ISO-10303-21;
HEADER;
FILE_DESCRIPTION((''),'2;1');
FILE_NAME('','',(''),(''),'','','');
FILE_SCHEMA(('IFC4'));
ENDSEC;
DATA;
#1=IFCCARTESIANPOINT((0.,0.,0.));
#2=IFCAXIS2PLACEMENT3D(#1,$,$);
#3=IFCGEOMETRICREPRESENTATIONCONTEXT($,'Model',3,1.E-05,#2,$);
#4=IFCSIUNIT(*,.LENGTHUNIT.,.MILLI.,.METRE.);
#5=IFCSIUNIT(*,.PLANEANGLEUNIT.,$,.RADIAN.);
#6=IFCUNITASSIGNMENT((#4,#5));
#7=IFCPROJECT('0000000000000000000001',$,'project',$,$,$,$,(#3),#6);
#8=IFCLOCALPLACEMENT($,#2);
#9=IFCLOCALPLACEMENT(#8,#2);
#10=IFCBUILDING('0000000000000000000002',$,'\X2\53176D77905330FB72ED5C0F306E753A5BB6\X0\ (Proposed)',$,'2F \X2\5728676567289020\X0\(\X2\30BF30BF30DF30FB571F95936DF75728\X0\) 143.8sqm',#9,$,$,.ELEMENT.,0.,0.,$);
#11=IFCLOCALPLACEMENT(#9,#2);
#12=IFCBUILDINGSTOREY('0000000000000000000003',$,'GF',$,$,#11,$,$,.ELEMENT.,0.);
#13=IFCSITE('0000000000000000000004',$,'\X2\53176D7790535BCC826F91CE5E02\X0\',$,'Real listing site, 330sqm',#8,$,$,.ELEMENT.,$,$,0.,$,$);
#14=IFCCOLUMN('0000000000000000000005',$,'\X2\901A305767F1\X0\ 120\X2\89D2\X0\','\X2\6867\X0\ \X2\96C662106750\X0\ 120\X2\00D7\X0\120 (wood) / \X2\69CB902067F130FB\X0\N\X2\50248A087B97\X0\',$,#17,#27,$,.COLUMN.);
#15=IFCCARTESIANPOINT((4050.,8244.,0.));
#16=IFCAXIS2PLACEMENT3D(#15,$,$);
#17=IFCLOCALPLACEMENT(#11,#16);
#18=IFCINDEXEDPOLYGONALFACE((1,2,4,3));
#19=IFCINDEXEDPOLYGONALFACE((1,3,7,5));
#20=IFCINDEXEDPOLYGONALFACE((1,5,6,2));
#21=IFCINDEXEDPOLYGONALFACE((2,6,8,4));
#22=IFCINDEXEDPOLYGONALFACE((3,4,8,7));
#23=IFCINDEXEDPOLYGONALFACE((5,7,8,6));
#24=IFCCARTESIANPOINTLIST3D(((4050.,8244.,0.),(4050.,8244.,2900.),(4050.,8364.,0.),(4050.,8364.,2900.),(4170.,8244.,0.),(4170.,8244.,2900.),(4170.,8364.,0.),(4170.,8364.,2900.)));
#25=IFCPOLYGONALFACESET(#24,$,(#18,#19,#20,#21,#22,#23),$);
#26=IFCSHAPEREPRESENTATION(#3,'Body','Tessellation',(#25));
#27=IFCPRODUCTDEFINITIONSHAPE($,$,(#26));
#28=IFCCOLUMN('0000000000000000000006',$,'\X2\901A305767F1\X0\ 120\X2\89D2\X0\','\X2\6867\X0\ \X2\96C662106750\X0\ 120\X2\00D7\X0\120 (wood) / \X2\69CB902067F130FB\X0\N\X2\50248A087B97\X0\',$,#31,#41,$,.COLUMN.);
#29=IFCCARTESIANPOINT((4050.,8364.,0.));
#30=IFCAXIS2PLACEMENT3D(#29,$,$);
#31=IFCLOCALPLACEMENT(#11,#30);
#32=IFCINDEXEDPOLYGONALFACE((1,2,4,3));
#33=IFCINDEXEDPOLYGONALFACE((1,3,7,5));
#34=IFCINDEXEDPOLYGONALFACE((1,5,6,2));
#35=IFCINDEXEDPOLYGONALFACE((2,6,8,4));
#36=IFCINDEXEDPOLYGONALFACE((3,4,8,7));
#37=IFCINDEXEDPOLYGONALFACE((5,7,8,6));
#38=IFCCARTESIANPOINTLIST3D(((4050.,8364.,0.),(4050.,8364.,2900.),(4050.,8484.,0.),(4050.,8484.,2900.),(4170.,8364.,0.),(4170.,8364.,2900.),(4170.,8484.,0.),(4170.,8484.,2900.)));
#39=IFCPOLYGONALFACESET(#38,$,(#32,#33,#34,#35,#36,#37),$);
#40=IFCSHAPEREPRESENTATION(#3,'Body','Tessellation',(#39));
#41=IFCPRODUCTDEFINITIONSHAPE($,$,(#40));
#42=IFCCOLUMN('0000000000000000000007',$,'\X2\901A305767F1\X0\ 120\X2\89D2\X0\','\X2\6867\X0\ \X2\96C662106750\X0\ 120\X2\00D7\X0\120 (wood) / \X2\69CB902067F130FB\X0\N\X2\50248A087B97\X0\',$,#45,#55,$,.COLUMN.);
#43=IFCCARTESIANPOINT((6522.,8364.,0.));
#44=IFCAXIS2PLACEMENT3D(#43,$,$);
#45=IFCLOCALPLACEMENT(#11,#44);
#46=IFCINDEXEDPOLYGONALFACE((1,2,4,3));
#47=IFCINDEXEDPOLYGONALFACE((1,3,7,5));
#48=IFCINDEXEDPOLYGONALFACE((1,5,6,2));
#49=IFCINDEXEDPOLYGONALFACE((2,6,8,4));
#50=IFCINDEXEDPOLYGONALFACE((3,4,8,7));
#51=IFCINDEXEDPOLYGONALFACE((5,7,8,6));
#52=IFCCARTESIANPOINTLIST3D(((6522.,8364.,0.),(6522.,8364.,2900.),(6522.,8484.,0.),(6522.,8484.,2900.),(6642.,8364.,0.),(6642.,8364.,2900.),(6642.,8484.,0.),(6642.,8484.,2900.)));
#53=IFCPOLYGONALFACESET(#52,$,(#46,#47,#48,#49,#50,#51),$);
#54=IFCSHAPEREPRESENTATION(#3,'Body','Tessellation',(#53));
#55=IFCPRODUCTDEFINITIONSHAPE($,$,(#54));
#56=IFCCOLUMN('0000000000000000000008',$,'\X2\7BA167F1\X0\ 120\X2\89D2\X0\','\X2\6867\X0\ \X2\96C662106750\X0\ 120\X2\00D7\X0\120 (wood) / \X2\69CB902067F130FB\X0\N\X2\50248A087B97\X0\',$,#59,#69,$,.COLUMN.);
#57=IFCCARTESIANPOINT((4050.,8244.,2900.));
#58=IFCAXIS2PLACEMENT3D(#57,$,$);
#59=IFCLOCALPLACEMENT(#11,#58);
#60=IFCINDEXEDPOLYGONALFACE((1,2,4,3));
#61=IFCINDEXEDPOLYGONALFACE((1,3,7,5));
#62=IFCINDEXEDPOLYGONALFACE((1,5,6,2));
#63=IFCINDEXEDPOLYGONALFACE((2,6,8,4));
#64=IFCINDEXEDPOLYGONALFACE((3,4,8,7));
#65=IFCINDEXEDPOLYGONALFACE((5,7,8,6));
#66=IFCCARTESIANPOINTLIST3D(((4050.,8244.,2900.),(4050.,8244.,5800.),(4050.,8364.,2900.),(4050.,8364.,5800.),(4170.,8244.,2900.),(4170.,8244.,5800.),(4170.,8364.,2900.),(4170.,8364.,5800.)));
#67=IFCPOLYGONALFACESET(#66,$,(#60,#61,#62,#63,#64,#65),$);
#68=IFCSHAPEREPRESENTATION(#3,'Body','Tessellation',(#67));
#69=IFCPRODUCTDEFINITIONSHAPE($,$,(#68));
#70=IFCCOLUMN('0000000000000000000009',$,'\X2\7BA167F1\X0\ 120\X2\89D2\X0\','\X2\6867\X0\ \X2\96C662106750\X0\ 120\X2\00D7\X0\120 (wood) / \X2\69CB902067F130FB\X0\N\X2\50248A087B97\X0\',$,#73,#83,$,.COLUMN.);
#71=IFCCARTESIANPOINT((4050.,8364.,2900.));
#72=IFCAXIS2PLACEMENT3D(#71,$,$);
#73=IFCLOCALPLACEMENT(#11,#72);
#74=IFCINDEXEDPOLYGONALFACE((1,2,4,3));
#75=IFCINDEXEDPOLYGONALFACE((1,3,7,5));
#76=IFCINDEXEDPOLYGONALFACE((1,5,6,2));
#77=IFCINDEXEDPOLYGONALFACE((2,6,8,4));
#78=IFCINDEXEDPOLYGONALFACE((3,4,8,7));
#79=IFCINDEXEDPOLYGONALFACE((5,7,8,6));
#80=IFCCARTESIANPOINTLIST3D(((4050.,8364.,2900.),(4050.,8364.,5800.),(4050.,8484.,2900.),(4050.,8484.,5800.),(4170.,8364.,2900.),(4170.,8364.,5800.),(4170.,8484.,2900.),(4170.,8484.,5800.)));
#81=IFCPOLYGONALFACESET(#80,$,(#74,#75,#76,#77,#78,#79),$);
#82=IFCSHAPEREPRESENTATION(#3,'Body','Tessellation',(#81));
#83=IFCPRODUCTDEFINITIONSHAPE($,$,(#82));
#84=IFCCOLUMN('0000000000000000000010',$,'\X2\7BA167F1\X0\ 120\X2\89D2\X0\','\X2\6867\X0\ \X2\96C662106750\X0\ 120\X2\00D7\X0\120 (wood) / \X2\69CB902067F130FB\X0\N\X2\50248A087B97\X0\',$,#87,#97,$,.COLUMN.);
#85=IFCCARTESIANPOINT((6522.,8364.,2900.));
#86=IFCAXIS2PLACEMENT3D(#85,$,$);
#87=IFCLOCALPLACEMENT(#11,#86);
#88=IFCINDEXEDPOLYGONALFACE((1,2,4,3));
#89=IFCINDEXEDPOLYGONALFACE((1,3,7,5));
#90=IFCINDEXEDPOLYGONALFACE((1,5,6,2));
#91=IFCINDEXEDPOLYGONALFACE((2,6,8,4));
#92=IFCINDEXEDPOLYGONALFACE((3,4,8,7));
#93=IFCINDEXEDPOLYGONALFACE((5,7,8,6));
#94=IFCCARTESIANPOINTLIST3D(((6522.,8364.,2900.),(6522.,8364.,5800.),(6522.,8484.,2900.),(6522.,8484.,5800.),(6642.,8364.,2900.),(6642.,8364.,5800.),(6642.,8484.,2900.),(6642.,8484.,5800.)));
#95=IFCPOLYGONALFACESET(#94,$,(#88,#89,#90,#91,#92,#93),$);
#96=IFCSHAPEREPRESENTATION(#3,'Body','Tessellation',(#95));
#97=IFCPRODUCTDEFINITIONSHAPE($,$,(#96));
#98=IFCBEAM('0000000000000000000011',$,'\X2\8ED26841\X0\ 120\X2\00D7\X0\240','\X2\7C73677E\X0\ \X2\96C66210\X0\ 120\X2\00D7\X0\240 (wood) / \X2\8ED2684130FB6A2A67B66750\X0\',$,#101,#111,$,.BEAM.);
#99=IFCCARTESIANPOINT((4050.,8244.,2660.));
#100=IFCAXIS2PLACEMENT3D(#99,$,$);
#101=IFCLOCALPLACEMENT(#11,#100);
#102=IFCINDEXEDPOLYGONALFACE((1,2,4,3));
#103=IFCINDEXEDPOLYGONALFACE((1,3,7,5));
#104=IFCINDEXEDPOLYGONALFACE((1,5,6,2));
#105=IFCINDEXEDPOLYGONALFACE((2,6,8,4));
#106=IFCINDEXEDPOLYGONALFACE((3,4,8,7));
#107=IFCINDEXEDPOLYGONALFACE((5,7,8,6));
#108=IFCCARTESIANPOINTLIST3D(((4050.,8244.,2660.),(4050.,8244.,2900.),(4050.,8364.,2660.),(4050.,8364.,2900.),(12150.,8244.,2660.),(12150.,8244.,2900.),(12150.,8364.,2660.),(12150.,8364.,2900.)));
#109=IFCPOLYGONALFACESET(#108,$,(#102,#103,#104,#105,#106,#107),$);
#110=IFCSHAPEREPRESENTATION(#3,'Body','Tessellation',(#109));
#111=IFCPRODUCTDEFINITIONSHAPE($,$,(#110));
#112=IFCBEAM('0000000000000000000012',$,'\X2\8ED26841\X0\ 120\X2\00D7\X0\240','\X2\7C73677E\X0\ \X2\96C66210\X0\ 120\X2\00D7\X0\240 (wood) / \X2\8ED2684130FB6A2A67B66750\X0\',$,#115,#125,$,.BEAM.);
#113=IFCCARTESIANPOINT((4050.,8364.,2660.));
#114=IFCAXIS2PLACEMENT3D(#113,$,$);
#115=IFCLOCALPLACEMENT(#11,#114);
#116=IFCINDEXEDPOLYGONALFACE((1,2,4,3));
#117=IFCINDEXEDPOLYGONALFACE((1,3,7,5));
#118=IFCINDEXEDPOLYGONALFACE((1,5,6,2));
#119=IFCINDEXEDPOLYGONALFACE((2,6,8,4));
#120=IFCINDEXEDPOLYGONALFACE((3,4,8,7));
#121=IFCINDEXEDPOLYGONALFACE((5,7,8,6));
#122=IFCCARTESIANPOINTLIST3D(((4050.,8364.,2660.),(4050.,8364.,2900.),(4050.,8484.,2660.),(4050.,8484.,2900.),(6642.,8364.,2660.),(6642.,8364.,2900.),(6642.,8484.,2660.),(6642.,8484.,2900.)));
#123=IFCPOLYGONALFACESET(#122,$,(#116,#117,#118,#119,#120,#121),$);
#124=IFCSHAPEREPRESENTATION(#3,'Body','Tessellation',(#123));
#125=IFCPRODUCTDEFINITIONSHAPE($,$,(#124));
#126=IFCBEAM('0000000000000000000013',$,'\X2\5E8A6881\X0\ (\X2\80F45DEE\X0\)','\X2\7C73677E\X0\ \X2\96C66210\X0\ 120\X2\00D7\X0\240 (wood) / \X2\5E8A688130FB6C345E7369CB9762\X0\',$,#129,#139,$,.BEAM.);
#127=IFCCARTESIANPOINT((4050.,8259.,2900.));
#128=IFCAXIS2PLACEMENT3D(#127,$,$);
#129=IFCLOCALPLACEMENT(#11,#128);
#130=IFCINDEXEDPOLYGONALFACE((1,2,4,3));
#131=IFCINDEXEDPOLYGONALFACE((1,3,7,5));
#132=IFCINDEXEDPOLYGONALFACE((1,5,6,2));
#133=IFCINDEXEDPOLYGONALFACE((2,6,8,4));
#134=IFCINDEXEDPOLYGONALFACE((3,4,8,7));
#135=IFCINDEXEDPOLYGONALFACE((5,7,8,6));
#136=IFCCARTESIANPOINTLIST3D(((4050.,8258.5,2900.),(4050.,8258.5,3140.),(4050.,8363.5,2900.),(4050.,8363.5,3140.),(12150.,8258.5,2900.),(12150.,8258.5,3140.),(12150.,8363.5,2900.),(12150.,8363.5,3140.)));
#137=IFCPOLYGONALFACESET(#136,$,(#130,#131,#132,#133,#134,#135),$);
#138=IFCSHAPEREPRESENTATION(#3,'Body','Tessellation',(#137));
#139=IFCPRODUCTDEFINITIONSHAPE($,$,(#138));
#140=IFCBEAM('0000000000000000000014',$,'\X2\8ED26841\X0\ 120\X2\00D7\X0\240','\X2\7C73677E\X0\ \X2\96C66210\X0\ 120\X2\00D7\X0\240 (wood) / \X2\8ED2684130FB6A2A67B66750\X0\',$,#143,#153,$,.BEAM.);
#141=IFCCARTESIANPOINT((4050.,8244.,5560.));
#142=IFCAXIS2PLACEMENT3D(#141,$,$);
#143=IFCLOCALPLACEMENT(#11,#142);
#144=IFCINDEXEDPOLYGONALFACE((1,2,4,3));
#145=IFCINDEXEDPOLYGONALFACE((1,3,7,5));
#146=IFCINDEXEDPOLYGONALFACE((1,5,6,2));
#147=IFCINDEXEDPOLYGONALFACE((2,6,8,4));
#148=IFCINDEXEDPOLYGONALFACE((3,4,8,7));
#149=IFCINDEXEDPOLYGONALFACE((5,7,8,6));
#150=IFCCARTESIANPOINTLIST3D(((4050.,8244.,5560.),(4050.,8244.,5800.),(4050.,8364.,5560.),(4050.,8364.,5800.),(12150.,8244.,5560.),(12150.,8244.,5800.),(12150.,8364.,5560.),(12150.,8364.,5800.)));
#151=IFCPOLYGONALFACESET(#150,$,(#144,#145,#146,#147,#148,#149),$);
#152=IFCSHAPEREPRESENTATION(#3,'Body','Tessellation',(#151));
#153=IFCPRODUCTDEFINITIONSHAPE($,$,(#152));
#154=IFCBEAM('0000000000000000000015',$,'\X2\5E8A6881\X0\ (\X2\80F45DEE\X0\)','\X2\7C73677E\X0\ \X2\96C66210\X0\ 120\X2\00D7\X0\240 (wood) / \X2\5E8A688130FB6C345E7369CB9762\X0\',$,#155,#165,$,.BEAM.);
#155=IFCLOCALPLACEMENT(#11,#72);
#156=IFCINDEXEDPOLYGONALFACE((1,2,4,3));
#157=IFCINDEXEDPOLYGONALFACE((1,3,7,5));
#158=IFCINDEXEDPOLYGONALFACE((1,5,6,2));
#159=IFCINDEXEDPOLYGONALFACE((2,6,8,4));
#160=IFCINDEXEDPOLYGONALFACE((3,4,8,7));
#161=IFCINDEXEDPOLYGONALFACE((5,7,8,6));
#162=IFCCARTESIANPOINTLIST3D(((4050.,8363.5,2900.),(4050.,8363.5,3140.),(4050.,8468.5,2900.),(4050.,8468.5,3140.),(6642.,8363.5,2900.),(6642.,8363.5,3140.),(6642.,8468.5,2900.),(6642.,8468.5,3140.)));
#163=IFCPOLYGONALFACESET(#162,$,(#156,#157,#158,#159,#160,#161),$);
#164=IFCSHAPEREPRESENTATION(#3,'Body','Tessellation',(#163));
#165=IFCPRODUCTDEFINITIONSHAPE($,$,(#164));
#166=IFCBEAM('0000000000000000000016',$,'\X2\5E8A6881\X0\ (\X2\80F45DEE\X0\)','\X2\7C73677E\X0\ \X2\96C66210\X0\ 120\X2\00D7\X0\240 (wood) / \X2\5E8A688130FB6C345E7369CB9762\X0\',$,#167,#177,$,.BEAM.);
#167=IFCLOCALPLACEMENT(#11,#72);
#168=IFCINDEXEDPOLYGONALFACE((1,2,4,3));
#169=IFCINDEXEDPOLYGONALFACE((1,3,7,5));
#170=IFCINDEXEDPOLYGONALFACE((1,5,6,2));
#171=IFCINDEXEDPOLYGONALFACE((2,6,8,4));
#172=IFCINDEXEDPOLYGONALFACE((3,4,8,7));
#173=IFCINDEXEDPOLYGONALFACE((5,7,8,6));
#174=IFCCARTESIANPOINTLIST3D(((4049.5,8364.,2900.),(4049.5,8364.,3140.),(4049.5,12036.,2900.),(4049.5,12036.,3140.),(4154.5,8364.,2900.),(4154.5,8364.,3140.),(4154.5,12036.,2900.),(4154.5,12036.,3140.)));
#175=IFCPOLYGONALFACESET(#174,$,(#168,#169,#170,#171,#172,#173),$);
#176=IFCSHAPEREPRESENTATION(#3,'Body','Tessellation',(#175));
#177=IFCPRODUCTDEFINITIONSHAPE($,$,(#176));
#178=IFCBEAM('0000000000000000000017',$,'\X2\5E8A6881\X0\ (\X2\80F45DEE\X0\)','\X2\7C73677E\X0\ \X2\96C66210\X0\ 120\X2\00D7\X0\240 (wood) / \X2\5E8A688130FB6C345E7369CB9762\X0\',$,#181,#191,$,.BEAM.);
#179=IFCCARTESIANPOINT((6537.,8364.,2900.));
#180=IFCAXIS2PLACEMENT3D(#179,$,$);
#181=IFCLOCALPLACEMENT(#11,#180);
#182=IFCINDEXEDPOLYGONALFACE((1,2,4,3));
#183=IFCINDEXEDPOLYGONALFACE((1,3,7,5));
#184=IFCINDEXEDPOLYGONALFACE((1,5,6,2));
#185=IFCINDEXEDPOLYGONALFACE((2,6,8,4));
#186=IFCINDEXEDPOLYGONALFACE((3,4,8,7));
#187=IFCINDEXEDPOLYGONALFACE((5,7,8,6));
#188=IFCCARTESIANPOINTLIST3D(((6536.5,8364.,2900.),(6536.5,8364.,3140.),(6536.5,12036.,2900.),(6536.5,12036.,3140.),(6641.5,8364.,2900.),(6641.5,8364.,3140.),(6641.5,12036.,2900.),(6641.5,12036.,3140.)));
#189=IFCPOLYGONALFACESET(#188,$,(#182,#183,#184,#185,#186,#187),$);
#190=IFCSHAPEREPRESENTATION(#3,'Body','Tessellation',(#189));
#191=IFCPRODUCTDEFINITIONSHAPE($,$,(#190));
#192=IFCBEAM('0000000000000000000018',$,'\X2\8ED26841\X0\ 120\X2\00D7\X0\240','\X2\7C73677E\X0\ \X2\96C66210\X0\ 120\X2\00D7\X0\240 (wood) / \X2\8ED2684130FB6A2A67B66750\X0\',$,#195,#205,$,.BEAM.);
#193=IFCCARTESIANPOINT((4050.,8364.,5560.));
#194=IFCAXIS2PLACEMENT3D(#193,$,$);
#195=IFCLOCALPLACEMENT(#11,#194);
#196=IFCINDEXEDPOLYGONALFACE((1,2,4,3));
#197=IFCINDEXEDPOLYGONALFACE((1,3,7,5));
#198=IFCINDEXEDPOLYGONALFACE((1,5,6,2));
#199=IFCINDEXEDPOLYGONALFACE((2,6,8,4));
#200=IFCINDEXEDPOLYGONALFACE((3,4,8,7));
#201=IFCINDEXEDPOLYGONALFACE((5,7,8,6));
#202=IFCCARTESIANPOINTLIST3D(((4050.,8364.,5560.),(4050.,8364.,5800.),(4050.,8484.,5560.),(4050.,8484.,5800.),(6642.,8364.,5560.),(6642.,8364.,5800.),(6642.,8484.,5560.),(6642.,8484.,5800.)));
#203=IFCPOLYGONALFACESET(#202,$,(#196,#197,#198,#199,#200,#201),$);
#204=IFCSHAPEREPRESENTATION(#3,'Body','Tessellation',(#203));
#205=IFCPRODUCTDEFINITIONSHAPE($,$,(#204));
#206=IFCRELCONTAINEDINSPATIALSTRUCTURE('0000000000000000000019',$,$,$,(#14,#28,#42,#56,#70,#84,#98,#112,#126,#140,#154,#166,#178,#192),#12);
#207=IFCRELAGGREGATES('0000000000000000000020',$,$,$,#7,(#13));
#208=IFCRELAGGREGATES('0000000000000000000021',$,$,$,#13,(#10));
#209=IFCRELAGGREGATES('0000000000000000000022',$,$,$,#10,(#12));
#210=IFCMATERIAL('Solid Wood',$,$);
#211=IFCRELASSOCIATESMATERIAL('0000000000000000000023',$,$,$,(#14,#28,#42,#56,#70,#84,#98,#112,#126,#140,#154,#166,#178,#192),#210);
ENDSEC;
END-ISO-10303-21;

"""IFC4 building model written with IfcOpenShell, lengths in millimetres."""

from ifc_helpers import new_model, si_unit, frame, frame_2d, origin, place, context, project, spatial, rectangle, extrude, material, element, save


model = new_model("IFC4")

# Units and contexts
model_context = context("Model", 3, precision=1e-05, world=origin())
ifc_project = project(units=[si_unit("LENGTHUNIT", "METRE", prefix="MILLI"), si_unit("PLANEANGLEUNIT", "RADIAN")], contexts=[model_context])

# Site, building, storey
site_placement = place(None, origin())
site = spatial("IfcSite", under=ifc_project, at=site_placement, Name="北海道富良野市", ObjectType="Real listing site, 330sqm", CompositionType="ELEMENT", RefElevation=0.0)
building_placement = place(site_placement, origin())
building = spatial("IfcBuilding", under=site, at=building_placement, Name="北海道・狭小の町家 (Proposed)", ObjectType="2F 在来木造(タタミ・土間混在) 143.8sqm", CompositionType="ELEMENT", ElevationOfRefHeight=0.0, ElevationOfTerrain=0.0)
storey_placement = place(building_placement, origin())
storey = spatial("IfcBuildingStorey", under=building, at=storey_placement, Name="GF", CompositionType="ELEMENT", Elevation=0.0)

# Columns
ifc_material_1 = material(Name="Solid Wood")
column_1_placement = place(storey_placement, frame((4050.0, 8244.0, 0.0)))
element("IfcColumn", 1, at=column_1_placement, inside=storey, material=ifc_material_1, Name="通し柱 120角", Description="桧 集成材 120×120 (wood) / 構造柱・N値計算", PredefinedType="COLUMN", context=model_context, shape_type="SweptSolid", body=[
    extrude(rectangle(XDim=120.0, YDim=120.0, at=frame_2d((60.0, 60.0))), frame((4050.0, 8244.0, 0.0)), (0.0, 0.0, 1.0), 2900.0),
])
column_2_placement = place(storey_placement, frame((4050.0, 8364.0, 0.0)))
element("IfcColumn", 2, at=column_2_placement, inside=storey, material=ifc_material_1, Name="通し柱 120角", Description="桧 集成材 120×120 (wood) / 構造柱・N値計算", PredefinedType="COLUMN", context=model_context, shape_type="SweptSolid", body=[
    extrude(rectangle(XDim=120.0, YDim=120.0, at=frame_2d((60.0, 60.0))), frame((4050.0, 8364.0, 0.0)), (0.0, 0.0, 1.0), 2900.0),
])
column_3_placement = place(storey_placement, frame((6522.0, 8364.0, 0.0)))
element("IfcColumn", 3, at=column_3_placement, inside=storey, material=ifc_material_1, Name="通し柱 120角", Description="桧 集成材 120×120 (wood) / 構造柱・N値計算", PredefinedType="COLUMN", context=model_context, shape_type="SweptSolid", body=[
    extrude(rectangle(XDim=120.0, YDim=120.0, at=frame_2d((60.0, 60.0))), frame((6522.0, 8364.0, 0.0)), (0.0, 0.0, 1.0), 2900.0),
])
column_4_placement = place(storey_placement, frame((4050.0, 8244.0, 2900.0)))
element("IfcColumn", 4, at=column_4_placement, inside=storey, material=ifc_material_1, Name="管柱 120角", Description="桧 集成材 120×120 (wood) / 構造柱・N値計算", PredefinedType="COLUMN", context=model_context, shape_type="SweptSolid", body=[
    extrude(rectangle(XDim=120.0, YDim=120.0, at=frame_2d((60.0, 60.0))), frame((4050.0, 8244.0, 2900.0)), (0.0, 0.0, 1.0), 2900.0),
])
column_5_placement = place(storey_placement, frame((4050.0, 8364.0, 2900.0)))
element("IfcColumn", 5, at=column_5_placement, inside=storey, material=ifc_material_1, Name="管柱 120角", Description="桧 集成材 120×120 (wood) / 構造柱・N値計算", PredefinedType="COLUMN", context=model_context, shape_type="SweptSolid", body=[
    extrude(rectangle(XDim=120.0, YDim=120.0, at=frame_2d((60.0, 60.0))), frame((4050.0, 8364.0, 2900.0)), (0.0, 0.0, 1.0), 2900.0),
])
column_6_placement = place(storey_placement, frame((6522.0, 8364.0, 2900.0)))
element("IfcColumn", 6, at=column_6_placement, inside=storey, material=ifc_material_1, Name="管柱 120角", Description="桧 集成材 120×120 (wood) / 構造柱・N値計算", PredefinedType="COLUMN", context=model_context, shape_type="SweptSolid", body=[
    extrude(rectangle(XDim=120.0, YDim=120.0, at=frame_2d((60.0, 60.0))), frame((6522.0, 8364.0, 2900.0)), (0.0, 0.0, 1.0), 2900.0),
])

# Beams
beam_1_placement = place(storey_placement, frame((4050.0, 8244.0, 2660.0)))
element("IfcBeam", 7, at=beam_1_placement, inside=storey, material=ifc_material_1, Name="軒桁 120×240", Description="米松 集成 120×240 (wood) / 軒桁・横架材", PredefinedType="BEAM", context=model_context, shape_type="SweptSolid", body=[
    extrude(rectangle(XDim=8100.0, YDim=120.0, at=frame_2d((4050.0, 60.0))), frame((4050.0, 8244.0, 2660.0)), (0.0, 0.0, 1.0), 240.0),
])
beam_2_placement = place(storey_placement, frame((4050.0, 8364.0, 2660.0)))
element("IfcBeam", 8, at=beam_2_placement, inside=storey, material=ifc_material_1, Name="軒桁 120×240", Description="米松 集成 120×240 (wood) / 軒桁・横架材", PredefinedType="BEAM", context=model_context, shape_type="SweptSolid", body=[
    extrude(rectangle(XDim=2592.0, YDim=120.0, at=frame_2d((1296.0, 60.0))), frame((4050.0, 8364.0, 2660.0)), (0.0, 0.0, 1.0), 240.0),
])
beam_3_placement = place(storey_placement, frame((4050.0, 8259.0, 2900.0)))
element("IfcBeam", 9, at=beam_3_placement, inside=storey, material=ifc_material_1, Name="床梁 (胴差)", Description="米松 集成 120×240 (wood) / 床梁・水平構面", PredefinedType="BEAM", context=model_context, shape_type="SweptSolid", body=[
    extrude(rectangle(XDim=8100.0, YDim=105.0, at=frame_2d((4050.0, 52.0))), frame((4050.0, 8259.0, 2900.0)), (0.0, 0.0, 1.0), 240.0),
])
beam_4_placement = place(storey_placement, frame((4050.0, 8244.0, 5560.0)))
element("IfcBeam", 10, at=beam_4_placement, inside=storey, material=ifc_material_1, Name="軒桁 120×240", Description="米松 集成 120×240 (wood) / 軒桁・横架材", PredefinedType="BEAM", context=model_context, shape_type="SweptSolid", body=[
    extrude(rectangle(XDim=8100.0, YDim=120.0, at=frame_2d((4050.0, 60.0))), frame((4050.0, 8244.0, 5560.0)), (0.0, 0.0, 1.0), 240.0),
])
beam_5_placement = place(storey_placement, frame((4050.0, 8364.0, 2900.0)))
element("IfcBeam", 11, at=beam_5_placement, inside=storey, material=ifc_material_1, Name="床梁 (胴差)", Description="米松 集成 120×240 (wood) / 床梁・水平構面", PredefinedType="BEAM", context=model_context, shape_type="SweptSolid", body=[
    extrude(rectangle(XDim=2592.0, YDim=105.0, at=frame_2d((1296.0, 52.0))), frame((4050.0, 8364.0, 2900.0)), (0.0, 0.0, 1.0), 240.0),
])
beam_6_placement = place(storey_placement, frame((4050.0, 8364.0, 2900.0)))
element("IfcBeam", 12, at=beam_6_placement, inside=storey, material=ifc_material_1, Name="床梁 (胴差)", Description="米松 集成 120×240 (wood) / 床梁・水平構面", PredefinedType="BEAM", context=model_context, shape_type="SweptSolid", body=[
    extrude(rectangle(XDim=105.0, YDim=3672.0, at=frame_2d((52.0, 1836.0))), frame((4050.0, 8364.0, 2900.0)), (0.0, 0.0, 1.0), 240.0),
])
beam_7_placement = place(storey_placement, frame((6537.0, 8364.0, 2900.0)))
element("IfcBeam", 13, at=beam_7_placement, inside=storey, material=ifc_material_1, Name="床梁 (胴差)", Description="米松 集成 120×240 (wood) / 床梁・水平構面", PredefinedType="BEAM", context=model_context, shape_type="SweptSolid", body=[
    extrude(rectangle(XDim=105.0, YDim=3672.0, at=frame_2d((52.0, 1836.0))), frame((6537.0, 8364.0, 2900.0)), (0.0, 0.0, 1.0), 240.0),
])
beam_8_placement = place(storey_placement, frame((4050.0, 8364.0, 5560.0)))
element("IfcBeam", 14, at=beam_8_placement, inside=storey, material=ifc_material_1, Name="軒桁 120×240", Description="米松 集成 120×240 (wood) / 軒桁・横架材", PredefinedType="BEAM", context=model_context, shape_type="SweptSolid", body=[
    extrude(rectangle(XDim=2592.0, YDim=120.0, at=frame_2d((1296.0, 60.0))), frame((4050.0, 8364.0, 5560.0)), (0.0, 0.0, 1.0), 240.0),
])

save(model, "model.ifc")
